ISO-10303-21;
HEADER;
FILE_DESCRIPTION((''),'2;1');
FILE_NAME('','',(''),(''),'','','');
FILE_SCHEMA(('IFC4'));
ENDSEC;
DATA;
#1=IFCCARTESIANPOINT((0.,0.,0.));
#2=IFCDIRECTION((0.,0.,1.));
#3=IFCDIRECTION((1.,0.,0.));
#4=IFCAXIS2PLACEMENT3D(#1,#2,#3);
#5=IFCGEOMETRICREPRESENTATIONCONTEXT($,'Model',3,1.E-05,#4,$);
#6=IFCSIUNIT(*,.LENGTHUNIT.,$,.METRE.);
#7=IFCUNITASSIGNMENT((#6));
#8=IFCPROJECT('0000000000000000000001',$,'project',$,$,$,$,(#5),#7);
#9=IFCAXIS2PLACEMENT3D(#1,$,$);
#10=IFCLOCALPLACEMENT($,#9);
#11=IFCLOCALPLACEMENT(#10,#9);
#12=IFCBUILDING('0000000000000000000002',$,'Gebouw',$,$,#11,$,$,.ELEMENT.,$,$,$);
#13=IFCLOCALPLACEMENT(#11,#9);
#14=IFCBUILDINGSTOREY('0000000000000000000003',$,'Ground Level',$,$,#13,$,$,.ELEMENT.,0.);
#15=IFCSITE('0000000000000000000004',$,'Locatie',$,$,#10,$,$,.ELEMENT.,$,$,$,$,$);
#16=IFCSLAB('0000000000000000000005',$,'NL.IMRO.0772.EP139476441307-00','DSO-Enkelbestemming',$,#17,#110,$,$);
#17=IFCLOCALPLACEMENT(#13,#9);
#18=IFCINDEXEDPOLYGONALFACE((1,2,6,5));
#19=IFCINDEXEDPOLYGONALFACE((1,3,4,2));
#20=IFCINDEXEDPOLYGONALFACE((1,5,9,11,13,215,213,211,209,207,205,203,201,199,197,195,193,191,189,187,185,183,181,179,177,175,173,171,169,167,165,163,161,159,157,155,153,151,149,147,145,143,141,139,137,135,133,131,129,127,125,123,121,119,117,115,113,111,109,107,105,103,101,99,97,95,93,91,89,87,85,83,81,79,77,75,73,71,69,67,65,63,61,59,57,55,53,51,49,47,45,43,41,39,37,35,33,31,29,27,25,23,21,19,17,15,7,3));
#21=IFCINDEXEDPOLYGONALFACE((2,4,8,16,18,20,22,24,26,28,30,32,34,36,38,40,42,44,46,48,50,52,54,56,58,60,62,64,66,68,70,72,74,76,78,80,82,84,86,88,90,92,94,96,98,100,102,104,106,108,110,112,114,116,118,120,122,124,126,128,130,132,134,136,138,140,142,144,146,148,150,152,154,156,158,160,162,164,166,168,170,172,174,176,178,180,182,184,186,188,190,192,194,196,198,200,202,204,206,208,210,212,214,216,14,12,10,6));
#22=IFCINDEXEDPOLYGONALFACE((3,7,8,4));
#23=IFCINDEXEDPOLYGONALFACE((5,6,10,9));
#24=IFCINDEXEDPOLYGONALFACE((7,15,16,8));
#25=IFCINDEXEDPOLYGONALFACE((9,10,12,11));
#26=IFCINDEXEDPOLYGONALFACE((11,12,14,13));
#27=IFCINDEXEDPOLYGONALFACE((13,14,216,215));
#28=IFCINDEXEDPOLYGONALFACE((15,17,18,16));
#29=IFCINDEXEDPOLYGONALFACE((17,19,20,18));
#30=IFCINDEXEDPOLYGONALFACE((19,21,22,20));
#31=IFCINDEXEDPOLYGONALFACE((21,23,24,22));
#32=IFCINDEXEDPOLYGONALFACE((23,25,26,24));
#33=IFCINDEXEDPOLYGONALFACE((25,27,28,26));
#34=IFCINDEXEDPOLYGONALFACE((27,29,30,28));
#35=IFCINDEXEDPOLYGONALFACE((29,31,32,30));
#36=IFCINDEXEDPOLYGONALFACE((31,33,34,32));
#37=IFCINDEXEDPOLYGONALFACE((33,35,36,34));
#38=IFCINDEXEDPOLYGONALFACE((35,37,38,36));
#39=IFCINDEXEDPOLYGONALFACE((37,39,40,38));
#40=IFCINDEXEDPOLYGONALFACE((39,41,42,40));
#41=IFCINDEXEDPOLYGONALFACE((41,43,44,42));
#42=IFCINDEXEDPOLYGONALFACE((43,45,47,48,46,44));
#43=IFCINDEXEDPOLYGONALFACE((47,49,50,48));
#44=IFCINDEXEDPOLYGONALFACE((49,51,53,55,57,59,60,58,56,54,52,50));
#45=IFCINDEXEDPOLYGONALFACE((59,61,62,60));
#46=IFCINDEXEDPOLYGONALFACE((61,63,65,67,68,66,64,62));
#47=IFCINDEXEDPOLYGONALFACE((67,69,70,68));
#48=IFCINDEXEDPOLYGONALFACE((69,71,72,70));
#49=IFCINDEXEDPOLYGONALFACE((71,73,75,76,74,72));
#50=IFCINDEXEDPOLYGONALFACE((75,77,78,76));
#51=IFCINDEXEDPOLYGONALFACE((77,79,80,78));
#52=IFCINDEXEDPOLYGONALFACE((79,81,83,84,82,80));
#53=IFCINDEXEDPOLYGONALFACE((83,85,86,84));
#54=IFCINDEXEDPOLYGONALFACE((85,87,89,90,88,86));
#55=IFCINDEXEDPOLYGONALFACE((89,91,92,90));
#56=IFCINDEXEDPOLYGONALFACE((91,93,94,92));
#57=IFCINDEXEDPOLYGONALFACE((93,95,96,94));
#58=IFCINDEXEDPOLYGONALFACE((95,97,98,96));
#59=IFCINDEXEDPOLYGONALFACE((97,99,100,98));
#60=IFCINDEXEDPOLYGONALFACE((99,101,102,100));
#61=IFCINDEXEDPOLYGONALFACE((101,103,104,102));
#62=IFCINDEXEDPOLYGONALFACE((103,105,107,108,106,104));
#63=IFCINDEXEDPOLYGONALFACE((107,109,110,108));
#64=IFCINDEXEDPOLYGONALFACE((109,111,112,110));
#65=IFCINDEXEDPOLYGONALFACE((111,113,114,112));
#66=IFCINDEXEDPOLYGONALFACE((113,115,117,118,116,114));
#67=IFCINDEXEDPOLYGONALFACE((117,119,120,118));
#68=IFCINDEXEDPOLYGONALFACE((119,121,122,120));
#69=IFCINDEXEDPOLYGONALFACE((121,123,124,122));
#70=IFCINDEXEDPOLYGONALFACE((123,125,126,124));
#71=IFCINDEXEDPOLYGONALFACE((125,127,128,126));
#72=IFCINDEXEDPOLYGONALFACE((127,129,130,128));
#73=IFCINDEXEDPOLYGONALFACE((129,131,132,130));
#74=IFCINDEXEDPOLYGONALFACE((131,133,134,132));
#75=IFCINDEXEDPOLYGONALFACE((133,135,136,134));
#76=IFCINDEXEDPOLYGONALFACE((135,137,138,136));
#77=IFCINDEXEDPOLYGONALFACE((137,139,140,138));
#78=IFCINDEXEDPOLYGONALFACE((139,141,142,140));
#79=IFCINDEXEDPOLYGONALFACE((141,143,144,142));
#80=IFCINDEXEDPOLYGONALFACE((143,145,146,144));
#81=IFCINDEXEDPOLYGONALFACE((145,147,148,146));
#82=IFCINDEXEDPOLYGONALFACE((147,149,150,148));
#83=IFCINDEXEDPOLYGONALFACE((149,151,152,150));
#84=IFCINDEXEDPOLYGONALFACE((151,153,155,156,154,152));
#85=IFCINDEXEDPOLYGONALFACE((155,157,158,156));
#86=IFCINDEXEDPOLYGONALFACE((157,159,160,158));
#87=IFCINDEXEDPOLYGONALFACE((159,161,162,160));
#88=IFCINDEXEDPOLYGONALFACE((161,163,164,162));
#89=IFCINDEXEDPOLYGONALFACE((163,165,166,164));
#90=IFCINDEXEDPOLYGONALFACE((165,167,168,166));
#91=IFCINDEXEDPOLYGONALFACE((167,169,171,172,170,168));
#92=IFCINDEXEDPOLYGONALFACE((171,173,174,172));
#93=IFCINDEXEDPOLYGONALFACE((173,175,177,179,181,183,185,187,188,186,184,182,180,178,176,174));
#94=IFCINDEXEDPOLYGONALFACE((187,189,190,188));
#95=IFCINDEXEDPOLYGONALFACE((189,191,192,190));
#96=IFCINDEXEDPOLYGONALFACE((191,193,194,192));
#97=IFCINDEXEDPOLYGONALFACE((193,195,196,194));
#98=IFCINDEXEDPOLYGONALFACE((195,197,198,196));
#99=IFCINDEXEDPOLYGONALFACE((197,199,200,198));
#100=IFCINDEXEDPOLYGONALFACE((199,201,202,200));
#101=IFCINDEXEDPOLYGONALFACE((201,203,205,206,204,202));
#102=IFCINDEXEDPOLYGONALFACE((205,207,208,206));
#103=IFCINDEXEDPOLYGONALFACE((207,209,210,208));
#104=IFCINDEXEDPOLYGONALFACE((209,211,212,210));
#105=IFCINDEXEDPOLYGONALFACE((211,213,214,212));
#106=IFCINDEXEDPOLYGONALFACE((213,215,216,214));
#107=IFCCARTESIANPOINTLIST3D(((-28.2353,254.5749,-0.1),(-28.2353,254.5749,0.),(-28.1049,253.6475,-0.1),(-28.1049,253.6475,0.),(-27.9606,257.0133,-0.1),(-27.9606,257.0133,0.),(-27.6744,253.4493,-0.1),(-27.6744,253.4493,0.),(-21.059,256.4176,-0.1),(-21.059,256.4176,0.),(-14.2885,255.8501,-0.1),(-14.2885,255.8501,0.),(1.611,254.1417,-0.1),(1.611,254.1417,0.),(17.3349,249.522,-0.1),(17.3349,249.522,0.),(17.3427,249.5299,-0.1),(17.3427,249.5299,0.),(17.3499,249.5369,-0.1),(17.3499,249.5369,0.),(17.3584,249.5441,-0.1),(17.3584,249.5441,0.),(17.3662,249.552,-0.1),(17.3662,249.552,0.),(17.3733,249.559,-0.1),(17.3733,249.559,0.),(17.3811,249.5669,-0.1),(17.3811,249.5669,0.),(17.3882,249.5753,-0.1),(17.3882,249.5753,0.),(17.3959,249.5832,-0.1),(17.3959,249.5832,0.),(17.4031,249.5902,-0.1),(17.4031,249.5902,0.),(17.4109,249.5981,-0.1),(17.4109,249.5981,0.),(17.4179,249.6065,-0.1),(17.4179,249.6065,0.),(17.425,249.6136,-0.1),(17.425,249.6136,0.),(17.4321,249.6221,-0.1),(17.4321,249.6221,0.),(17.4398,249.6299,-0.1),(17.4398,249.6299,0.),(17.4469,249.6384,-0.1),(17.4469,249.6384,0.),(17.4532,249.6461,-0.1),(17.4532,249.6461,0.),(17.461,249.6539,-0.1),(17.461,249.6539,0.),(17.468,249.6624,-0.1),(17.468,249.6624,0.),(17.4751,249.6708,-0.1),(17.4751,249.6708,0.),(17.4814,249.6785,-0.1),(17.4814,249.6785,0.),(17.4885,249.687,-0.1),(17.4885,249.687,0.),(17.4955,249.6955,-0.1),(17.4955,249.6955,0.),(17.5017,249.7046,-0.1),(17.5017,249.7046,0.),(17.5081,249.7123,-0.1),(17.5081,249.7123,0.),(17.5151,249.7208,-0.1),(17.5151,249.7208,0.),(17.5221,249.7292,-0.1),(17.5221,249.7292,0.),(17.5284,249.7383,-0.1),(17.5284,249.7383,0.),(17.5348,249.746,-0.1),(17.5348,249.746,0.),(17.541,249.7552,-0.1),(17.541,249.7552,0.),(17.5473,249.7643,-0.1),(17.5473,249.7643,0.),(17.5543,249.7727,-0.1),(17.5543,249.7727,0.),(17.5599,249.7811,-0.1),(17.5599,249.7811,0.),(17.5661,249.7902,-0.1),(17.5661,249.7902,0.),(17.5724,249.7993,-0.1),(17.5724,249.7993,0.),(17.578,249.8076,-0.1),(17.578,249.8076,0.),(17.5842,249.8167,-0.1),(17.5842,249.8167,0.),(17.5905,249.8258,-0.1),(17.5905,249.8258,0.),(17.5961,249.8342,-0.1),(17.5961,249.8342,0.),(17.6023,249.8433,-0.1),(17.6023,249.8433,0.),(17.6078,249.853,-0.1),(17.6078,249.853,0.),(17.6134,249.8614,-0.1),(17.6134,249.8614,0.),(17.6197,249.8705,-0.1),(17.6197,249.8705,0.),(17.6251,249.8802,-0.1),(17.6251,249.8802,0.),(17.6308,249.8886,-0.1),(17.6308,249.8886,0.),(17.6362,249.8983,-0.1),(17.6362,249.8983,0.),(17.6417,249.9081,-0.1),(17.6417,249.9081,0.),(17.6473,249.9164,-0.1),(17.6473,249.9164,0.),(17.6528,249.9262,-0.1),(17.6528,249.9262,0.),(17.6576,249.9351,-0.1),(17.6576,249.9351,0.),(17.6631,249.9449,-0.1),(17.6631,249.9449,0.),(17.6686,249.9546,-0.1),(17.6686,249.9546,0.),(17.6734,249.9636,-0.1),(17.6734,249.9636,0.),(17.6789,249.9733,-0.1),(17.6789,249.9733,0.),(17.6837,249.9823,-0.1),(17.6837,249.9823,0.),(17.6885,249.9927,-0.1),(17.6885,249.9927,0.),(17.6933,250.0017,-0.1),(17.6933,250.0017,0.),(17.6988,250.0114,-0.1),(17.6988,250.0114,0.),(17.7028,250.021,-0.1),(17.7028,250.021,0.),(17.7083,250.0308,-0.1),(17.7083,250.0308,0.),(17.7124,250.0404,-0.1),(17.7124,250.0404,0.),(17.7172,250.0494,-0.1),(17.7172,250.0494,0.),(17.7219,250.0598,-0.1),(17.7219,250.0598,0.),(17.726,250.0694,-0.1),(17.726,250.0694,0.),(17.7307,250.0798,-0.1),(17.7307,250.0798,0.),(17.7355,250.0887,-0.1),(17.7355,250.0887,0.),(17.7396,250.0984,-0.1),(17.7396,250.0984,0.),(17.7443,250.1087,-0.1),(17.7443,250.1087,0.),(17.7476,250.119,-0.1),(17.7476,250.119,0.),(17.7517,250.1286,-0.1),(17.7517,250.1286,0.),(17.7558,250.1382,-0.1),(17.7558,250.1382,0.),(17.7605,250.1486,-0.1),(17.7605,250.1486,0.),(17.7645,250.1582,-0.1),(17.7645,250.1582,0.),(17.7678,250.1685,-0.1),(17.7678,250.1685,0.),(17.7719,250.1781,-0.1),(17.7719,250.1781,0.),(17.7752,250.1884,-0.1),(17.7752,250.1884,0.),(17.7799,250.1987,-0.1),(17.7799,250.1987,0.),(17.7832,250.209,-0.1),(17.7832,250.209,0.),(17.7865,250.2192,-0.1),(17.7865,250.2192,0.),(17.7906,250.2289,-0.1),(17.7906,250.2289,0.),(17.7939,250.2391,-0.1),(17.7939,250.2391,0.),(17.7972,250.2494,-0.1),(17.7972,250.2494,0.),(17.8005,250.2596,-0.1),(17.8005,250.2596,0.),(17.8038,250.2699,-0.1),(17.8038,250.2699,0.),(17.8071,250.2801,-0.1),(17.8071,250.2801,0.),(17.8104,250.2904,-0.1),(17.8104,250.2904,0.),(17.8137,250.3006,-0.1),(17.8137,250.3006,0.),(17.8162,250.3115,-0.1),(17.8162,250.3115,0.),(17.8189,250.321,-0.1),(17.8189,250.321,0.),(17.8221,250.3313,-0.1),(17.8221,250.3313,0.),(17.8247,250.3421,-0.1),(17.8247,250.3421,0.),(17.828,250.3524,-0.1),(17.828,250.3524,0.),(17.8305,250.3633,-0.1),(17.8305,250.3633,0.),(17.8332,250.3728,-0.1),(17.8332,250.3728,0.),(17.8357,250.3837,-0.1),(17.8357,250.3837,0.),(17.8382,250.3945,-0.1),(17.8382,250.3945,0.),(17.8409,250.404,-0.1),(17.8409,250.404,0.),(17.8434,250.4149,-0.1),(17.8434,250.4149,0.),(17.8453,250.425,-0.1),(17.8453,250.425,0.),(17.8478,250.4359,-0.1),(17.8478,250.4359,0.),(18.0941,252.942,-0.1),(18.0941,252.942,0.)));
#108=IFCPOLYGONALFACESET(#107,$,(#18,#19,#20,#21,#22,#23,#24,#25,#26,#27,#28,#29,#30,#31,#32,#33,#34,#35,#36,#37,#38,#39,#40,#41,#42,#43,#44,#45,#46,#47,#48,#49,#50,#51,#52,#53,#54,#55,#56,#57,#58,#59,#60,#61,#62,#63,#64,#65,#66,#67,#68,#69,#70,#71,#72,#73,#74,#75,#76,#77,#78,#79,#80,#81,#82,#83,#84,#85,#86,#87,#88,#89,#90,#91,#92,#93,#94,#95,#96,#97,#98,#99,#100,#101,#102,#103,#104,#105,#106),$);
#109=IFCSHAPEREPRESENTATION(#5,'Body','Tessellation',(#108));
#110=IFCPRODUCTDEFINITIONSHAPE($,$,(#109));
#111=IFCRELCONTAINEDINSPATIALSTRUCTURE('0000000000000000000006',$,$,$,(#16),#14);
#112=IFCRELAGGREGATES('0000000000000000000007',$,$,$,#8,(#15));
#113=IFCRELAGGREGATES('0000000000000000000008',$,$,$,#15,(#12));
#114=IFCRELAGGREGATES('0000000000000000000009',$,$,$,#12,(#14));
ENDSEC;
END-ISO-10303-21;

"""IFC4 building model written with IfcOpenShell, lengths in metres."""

from ifc_helpers import new_model, si_unit, frame, origin, origin_with_axes, place, context, project, spatial, polyline, outline, extrude, element, save


model = new_model("IFC4")

# Units and contexts
model_context = context("Model", 3, precision=1e-05, world=origin_with_axes())
ifc_project = project(units=[si_unit("LENGTHUNIT", "METRE")], contexts=[model_context])

# Site, building, storey
site_placement = place(None, origin())
site = spatial("IfcSite", under=ifc_project, at=site_placement, Name="Locatie", CompositionType="ELEMENT")
building_placement = place(site_placement, origin())
building = spatial("IfcBuilding", under=site, at=building_placement, Name="Gebouw", CompositionType="ELEMENT")
storey_placement = place(building_placement, origin())
storey = spatial("IfcBuildingStorey", under=building, at=storey_placement, Name="Ground Level", CompositionType="ELEMENT", Elevation=0.0)

# Slab
slab_1_placement = place(storey_placement, origin())
element("IfcSlab", 1, at=slab_1_placement, inside=storey, Name="NL.IMRO.0772.EP139476441307-00", Description="DSO-Enkelbestemming", context=model_context, shape_type="SweptSolid", body=[
    extrude(outline(polyline([(-27.6744, 253.4493), (-28.1049, 253.6475), (-28.2353, 254.5749), (-27.9606, 257.0133), (-21.059, 256.4176), (-14.2885, 255.8501), (1.611, 254.1417), (18.0941, 252.942), (17.8478, 250.4359), (17.8453, 250.425), (17.8434, 250.4149), (17.8409, 250.404), (17.8382, 250.3945), (17.8357, 250.3837), (17.8332, 250.3728), (17.8305, 250.3633), (17.828, 250.3524), (17.8247, 250.3421), (17.8221, 250.3313), (17.8189, 250.321), (17.8162, 250.3115), (17.8137, 250.3006), (17.8104, 250.2904), (17.8071, 250.2801), (17.8038, 250.2699), (17.8005, 250.2596), (17.7972, 250.2494), (17.7939, 250.2391), (17.7906, 250.2289), (17.7865, 250.2192), (17.7832, 250.209), (17.7799, 250.1987), (17.7752, 250.1884), (17.7719, 250.1781), (17.7678, 250.1685), (17.7645, 250.1582), (17.7605, 250.1486), (17.7558, 250.1382), (17.7517, 250.1286), (17.7476, 250.119), (17.7443, 250.1087), (17.7396, 250.0984), (17.7355, 250.0887), (17.7307, 250.0798), (17.726, 250.0694), (17.7219, 250.0598), (17.7172, 250.0494), (17.7124, 250.0404), (17.7083, 250.0308), (17.7028, 250.021), (17.6988, 250.0114), (17.6933, 250.0017), (17.6885, 249.9927), (17.6837, 249.9823), (17.6789, 249.9733), (17.6734, 249.9636), (17.6686, 249.9546), (17.6631, 249.9449), (17.6576, 249.9351), (17.6528, 249.9262), (17.6473, 249.9164), (17.6417, 249.9081), (17.6362, 249.8983), (17.6308, 249.8886), (17.6251, 249.8802), (17.6197, 249.8705), (17.6134, 249.8614), (17.6078, 249.853), (17.6023, 249.8433), (17.5961, 249.8342), (17.5905, 249.8258), (17.5842, 249.8167), (17.578, 249.8076), (17.5724, 249.7993), (17.5661, 249.7902), (17.5599, 249.7811), (17.5543, 249.7727), (17.5473, 249.7643), (17.541, 249.7552), (17.5348, 249.746), (17.5284, 249.7383), (17.5221, 249.7292), (17.5151, 249.7208), (17.5081, 249.7123), (17.5017, 249.7046), (17.4955, 249.6955), (17.4885, 249.687), (17.4814, 249.6785), (17.4751, 249.6708), (17.468, 249.6624), (17.461, 249.6539), (17.4532, 249.6461), (17.4469, 249.6384), (17.4398, 249.6299), (17.4321, 249.6221), (17.425, 249.6136), (17.4179, 249.6065), (17.4109, 249.5981), (17.4031, 249.5902), (17.3959, 249.5832), (17.3882, 249.5753), (17.3811, 249.5669), (17.3733, 249.559), (17.3662, 249.552), (17.3584, 249.5441), (17.3499, 249.5369), (17.3427, 249.5299), (17.3349, 249.522), (-27.6744, 253.4493)])), frame((0.0, 0.0, -0.1), z_axis=(0.0, 0.0, 1.0), x_axis=(1.0, 0.0, 0.0)), (0.0, 0.0, 1.0), 0.1),
])

save(model, "model.ifc")
